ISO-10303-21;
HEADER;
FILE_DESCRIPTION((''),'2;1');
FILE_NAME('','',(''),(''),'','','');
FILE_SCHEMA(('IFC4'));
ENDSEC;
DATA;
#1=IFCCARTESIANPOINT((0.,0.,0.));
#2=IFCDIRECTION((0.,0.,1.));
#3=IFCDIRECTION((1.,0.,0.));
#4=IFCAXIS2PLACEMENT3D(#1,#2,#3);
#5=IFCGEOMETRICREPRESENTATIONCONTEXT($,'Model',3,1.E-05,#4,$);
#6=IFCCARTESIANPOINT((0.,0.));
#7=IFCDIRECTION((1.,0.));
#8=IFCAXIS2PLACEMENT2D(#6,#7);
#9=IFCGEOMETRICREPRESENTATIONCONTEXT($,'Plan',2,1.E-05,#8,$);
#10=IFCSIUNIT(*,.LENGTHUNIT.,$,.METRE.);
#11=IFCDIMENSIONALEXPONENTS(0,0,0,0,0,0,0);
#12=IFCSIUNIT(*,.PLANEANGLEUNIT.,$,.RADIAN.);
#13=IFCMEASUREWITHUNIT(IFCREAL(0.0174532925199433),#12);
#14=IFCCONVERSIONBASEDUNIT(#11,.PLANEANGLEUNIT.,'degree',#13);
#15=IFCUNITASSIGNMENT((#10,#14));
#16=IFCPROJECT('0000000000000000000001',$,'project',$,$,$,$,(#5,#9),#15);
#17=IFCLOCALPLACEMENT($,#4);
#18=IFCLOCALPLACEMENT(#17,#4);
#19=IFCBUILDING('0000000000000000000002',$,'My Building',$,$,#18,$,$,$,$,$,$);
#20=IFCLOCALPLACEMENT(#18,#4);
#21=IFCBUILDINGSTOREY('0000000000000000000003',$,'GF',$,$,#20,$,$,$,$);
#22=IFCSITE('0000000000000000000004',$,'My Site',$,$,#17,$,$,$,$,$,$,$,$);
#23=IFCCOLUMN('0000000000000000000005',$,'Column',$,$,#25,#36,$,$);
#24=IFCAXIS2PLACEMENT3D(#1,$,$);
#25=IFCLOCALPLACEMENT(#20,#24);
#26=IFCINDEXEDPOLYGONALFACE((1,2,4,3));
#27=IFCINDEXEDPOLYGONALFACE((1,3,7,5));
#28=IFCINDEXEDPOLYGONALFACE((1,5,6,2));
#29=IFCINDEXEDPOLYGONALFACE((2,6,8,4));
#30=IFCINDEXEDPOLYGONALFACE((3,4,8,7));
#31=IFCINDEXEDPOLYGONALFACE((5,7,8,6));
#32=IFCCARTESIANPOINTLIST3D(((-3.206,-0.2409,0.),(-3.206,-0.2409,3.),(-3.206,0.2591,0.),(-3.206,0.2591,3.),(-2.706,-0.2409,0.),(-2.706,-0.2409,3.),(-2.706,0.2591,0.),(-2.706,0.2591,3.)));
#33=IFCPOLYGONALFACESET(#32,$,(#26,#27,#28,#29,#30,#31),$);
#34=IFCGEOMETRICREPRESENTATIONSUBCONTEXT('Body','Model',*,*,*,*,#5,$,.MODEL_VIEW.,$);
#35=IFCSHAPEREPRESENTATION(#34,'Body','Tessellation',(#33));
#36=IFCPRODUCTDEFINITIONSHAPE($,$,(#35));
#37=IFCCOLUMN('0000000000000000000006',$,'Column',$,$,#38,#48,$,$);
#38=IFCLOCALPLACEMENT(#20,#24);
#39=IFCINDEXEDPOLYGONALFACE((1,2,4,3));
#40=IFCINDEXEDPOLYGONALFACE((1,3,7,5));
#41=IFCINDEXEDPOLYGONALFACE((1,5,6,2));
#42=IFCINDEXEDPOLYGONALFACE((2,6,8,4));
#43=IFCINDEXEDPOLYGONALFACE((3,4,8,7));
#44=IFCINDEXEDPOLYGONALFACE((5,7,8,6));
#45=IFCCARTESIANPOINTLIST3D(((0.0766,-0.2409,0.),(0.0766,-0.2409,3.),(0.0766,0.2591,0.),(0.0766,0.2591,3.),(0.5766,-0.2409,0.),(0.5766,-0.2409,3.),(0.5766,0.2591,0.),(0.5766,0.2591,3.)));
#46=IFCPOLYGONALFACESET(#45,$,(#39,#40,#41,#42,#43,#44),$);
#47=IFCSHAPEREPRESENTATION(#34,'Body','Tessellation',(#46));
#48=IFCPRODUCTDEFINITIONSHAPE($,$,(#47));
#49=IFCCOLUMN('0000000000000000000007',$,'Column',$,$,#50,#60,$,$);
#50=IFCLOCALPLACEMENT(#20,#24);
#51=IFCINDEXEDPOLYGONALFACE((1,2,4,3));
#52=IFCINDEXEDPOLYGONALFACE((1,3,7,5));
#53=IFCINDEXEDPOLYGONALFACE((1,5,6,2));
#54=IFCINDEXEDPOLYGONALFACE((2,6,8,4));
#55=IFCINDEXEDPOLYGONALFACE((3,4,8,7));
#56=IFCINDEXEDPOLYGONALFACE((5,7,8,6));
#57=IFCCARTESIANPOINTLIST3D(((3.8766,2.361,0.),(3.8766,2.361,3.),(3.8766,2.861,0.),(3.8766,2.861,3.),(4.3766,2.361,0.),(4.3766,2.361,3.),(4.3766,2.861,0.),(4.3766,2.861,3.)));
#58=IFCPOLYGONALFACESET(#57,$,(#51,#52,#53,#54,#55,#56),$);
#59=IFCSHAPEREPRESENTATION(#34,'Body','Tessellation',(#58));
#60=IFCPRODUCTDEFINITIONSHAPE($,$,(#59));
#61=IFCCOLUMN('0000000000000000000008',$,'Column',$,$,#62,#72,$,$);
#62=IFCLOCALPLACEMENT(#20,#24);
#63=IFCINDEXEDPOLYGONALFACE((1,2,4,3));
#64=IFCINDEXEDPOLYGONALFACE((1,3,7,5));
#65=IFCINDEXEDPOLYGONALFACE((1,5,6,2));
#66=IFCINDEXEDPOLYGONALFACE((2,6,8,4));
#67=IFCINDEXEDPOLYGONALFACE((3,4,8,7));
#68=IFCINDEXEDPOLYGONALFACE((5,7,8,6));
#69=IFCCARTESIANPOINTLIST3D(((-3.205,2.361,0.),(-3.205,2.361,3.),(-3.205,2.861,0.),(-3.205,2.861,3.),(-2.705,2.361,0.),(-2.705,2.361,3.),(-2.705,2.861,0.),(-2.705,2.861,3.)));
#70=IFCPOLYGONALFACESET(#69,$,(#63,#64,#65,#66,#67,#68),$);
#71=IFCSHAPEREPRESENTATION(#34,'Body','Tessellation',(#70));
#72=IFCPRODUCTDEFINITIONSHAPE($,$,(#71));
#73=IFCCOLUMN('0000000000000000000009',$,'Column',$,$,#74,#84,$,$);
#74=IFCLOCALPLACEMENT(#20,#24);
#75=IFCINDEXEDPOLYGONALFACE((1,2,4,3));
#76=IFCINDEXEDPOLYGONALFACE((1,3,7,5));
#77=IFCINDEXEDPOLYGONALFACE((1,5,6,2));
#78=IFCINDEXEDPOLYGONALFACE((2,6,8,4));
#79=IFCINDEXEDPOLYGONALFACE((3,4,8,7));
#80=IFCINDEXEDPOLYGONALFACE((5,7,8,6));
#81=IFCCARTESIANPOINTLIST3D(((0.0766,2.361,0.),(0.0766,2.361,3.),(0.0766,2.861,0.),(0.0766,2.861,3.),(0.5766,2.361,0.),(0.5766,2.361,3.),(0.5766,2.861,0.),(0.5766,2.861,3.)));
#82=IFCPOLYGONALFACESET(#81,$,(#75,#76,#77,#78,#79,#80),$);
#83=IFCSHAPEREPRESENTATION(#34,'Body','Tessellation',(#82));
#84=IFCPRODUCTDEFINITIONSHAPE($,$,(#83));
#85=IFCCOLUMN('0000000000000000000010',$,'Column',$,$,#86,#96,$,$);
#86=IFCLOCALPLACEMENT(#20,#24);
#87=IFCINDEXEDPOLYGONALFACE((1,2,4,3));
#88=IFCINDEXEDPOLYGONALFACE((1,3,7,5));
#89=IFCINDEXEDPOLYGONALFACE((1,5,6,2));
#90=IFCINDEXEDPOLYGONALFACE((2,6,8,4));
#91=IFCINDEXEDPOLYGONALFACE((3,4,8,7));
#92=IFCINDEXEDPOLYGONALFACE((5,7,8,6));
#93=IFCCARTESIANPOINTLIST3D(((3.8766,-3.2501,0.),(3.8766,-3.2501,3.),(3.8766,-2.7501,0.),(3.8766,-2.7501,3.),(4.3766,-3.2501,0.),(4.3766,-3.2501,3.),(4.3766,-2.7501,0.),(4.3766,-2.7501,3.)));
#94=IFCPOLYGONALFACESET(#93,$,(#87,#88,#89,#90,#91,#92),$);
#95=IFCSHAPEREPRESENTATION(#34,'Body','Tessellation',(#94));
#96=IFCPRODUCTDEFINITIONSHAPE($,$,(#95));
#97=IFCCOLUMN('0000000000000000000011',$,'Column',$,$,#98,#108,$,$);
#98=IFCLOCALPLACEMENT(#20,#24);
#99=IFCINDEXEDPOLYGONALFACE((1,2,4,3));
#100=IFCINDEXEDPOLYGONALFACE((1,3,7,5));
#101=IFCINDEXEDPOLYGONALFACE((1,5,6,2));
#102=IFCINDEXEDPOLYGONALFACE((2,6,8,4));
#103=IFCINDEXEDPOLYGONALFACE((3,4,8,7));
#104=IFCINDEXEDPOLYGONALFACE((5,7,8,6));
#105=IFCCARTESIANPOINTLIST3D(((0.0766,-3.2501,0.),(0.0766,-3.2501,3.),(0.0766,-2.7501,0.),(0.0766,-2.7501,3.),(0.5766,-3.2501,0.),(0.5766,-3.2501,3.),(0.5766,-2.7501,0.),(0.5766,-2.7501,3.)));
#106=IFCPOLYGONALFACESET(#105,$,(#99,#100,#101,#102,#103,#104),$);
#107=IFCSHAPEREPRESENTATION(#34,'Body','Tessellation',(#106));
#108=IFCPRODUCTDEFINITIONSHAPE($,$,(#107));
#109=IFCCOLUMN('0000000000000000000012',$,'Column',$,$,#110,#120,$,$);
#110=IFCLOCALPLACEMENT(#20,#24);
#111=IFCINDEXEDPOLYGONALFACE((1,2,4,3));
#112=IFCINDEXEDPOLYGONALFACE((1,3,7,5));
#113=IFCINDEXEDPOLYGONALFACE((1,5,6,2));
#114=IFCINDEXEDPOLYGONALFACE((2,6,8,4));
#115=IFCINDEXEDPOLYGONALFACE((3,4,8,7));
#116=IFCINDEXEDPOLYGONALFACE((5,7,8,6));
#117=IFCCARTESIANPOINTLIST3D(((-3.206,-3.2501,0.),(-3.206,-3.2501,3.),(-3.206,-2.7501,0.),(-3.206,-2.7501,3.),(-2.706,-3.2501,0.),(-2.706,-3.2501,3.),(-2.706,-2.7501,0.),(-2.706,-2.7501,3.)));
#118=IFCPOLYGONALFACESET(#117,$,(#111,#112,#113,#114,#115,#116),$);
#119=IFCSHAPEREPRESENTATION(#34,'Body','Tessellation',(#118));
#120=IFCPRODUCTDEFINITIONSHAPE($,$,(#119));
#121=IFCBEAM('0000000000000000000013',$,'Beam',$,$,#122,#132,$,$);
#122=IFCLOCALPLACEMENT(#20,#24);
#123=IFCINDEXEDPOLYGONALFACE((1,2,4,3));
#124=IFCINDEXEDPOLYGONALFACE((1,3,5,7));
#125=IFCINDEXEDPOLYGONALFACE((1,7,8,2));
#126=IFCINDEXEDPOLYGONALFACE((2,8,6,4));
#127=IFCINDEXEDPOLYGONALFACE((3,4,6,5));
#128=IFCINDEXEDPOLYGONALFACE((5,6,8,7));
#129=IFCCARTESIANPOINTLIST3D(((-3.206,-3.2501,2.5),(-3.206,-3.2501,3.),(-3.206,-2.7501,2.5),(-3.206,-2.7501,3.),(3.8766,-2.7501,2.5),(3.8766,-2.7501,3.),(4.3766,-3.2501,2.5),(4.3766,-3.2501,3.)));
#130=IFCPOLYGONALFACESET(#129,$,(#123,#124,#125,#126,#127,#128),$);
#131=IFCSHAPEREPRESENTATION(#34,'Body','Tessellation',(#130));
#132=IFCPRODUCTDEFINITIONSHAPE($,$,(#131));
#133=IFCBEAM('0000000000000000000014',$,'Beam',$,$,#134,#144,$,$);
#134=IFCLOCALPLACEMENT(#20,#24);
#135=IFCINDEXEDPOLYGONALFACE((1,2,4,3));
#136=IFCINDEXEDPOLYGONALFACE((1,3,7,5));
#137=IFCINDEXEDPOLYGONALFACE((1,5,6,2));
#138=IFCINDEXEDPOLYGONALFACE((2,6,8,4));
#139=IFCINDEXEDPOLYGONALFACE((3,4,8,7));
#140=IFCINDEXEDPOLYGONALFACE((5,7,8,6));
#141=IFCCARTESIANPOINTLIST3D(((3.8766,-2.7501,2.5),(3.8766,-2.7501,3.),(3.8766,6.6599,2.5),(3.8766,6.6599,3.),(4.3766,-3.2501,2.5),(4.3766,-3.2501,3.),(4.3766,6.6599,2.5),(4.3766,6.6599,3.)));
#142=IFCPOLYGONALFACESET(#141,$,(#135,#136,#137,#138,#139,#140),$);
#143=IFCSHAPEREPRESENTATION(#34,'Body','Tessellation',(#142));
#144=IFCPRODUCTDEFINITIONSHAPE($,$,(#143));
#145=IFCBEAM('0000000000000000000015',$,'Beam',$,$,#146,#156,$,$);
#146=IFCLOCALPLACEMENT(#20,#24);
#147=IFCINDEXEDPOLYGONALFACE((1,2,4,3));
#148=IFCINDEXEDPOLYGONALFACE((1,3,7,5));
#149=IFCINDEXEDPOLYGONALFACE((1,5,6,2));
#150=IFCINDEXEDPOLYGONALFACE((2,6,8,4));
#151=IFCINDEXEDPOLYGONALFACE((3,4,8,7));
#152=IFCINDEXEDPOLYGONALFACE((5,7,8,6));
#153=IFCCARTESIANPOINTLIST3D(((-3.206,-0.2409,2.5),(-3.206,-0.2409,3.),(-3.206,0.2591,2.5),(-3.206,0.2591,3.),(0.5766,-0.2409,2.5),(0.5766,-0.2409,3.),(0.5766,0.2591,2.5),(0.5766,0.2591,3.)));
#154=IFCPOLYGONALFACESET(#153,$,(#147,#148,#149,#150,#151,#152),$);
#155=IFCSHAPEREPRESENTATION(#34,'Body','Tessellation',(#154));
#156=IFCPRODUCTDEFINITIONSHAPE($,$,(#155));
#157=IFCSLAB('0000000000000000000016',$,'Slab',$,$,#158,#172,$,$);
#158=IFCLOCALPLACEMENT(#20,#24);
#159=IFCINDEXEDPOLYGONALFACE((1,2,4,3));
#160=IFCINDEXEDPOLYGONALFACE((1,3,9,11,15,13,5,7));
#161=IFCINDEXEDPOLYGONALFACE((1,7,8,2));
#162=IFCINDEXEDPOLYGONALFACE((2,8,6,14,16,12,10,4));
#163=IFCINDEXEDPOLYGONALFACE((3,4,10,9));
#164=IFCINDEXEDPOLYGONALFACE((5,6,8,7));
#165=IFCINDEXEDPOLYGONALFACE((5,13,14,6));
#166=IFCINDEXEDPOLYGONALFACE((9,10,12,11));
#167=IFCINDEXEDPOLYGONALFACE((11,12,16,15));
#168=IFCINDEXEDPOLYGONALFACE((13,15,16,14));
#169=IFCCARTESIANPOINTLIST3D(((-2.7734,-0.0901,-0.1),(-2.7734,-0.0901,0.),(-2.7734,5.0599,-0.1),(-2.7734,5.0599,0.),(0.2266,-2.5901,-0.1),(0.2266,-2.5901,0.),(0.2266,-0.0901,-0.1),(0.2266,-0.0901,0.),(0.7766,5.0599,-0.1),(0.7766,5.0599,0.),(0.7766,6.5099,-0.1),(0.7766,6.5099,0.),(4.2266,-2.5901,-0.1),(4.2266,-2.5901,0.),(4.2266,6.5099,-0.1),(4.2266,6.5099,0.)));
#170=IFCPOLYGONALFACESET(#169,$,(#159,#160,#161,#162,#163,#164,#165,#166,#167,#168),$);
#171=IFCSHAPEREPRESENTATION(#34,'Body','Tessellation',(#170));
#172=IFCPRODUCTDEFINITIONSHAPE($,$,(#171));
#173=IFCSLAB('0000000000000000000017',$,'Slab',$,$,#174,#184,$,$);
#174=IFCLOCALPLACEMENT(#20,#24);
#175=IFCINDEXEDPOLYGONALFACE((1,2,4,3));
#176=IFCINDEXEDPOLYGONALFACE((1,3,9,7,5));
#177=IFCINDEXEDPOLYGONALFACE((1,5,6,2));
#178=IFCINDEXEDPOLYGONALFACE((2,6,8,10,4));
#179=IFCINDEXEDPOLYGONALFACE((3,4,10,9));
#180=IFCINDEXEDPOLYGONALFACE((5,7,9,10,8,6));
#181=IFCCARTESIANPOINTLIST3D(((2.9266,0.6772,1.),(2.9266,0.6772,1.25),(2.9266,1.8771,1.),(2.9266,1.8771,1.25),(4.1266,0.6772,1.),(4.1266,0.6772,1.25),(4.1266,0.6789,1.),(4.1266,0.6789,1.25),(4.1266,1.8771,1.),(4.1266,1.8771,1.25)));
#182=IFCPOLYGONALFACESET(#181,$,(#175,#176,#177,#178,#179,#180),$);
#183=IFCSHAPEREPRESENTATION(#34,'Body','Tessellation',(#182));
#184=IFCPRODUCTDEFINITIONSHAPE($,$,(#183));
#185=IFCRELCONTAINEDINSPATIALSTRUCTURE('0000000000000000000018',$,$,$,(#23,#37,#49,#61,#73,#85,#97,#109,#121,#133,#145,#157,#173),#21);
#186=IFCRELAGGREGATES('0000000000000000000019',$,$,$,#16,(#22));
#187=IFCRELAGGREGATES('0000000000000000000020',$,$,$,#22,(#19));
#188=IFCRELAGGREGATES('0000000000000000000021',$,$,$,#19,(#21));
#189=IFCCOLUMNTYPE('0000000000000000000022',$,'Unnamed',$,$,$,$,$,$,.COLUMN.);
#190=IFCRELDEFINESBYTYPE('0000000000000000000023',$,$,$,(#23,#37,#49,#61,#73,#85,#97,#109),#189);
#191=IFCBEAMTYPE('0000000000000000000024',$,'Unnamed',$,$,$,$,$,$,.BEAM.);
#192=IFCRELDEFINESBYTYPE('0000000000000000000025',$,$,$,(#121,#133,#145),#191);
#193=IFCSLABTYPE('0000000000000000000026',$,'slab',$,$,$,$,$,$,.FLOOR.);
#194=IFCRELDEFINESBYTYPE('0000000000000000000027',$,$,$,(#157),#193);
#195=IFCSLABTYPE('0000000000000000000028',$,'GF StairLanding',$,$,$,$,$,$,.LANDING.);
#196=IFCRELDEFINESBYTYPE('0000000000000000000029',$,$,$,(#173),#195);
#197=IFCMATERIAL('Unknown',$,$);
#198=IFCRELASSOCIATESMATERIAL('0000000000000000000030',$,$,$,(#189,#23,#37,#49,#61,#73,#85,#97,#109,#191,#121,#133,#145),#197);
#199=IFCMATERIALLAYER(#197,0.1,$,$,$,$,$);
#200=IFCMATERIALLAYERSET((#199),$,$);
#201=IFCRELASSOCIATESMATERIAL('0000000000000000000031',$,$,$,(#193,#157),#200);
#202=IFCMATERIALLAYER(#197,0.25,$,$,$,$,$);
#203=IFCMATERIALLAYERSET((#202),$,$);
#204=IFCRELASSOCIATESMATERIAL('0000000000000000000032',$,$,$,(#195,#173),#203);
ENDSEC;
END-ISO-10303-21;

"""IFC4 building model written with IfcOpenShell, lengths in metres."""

from ifc_helpers import new_model, entity, si_unit, converted_unit, frame, origin_with_axes, origin_2d_with_axis, place, context, subcontext, project, spatial, indexed_curve, rectangle, outline, extrude, clip, halfspace, material, layer, layer_set, layer_usage, material_profile, profile_set, profile_usage, type_object, element, save


model = new_model("IFC4")

# Units and contexts
model_context = context("Model", 3, precision=1e-05, world=origin_with_axes())
plan_context = context("Plan", 2, precision=1e-05, world=origin_2d_with_axis())
body_context_1 = subcontext(model_context, "Body", "Model", "MODEL_VIEW")
ifc_project = project(units=[si_unit("LENGTHUNIT", "METRE"), converted_unit("PLANEANGLEUNIT", "degree", entity("IfcReal", 0.0174532925199433), si_unit("PLANEANGLEUNIT", "RADIAN"), dimensions=[0, 0, 0, 0, 0, 0, 0])], contexts=[model_context, plan_context])

# Site, building, storey
site_placement = place(None, origin_with_axes())
site = spatial("IfcSite", under=ifc_project, at=site_placement, Name="My Site")
building_placement = place(site_placement, origin_with_axes())
building = spatial("IfcBuilding", under=site, at=building_placement, Name="My Building")
storey_placement = place(building_placement, origin_with_axes())
storey = spatial("IfcBuildingStorey", under=building, at=storey_placement, Name="GF")

# Columns
ifc_material = material(Name="Unknown")
ifc_material_profile_1 = material_profile(ifc_material, rectangle(XDim=0.5, YDim=0.5))
ifc_profile_set_1 = profile_set([ifc_material_profile_1])
ifc_profile_usage_1 = profile_usage(ifc_profile_set_1, cardinal=5)
column_type = type_object("IfcColumnType", Name="Unnamed", PredefinedType="COLUMN", material=ifc_profile_set_1)
column_1_placement = place(storey_placement, frame((-2.956, 0.0091, 0.0), z_axis=(0.0, 0.0, 1.0), x_axis=(1.0, 0.0, 0.0)))
element("IfcColumn", 1, at=column_1_placement, inside=storey, type_object=column_type, material=ifc_profile_usage_1, Name="Column", context=body_context_1, shape_type="SweptSolid", body=[
    extrude(rectangle(XDim=0.5, YDim=0.5), origin_with_axes(), (0.0, 0.0, 1.0), 3.0),
])
ifc_profile_usage_2 = profile_usage(ifc_profile_set_1, cardinal=5)
column_2_placement = place(storey_placement, frame((0.3266, 0.0091, 0.0), z_axis=(0.0, 0.0, 1.0), x_axis=(1.0, 0.0, 0.0)))
element("IfcColumn", 2, at=column_2_placement, inside=storey, type_object=column_type, material=ifc_profile_usage_2, Name="Column", context=body_context_1, shape_type="SweptSolid", body=[
    extrude(rectangle(XDim=0.5, YDim=0.5), origin_with_axes(), (0.0, 0.0, 1.0), 3.0),
])
ifc_profile_usage_3 = profile_usage(ifc_profile_set_1, cardinal=5)
column_3_placement = place(storey_placement, frame((4.1266, 2.611, 0.0), z_axis=(0.0, 0.0, 1.0), x_axis=(1.0, 0.0, 0.0)))
element("IfcColumn", 3, at=column_3_placement, inside=storey, type_object=column_type, material=ifc_profile_usage_3, Name="Column", context=body_context_1, shape_type="SweptSolid", body=[
    extrude(rectangle(XDim=0.5, YDim=0.5), origin_with_axes(), (0.0, 0.0, 1.0), 3.0),
])
ifc_profile_usage_4 = profile_usage(ifc_profile_set_1, cardinal=5)
column_4_placement = place(storey_placement, frame((-2.955, 2.611, 0.0), z_axis=(0.0, 0.0, 1.0), x_axis=(1.0, 0.0, 0.0)))
element("IfcColumn", 4, at=column_4_placement, inside=storey, type_object=column_type, material=ifc_profile_usage_4, Name="Column", context=body_context_1, shape_type="SweptSolid", body=[
    extrude(rectangle(XDim=0.5, YDim=0.5), origin_with_axes(), (0.0, 0.0, 1.0), 3.0),
])
ifc_profile_usage_5 = profile_usage(ifc_profile_set_1, cardinal=5)
column_5_placement = place(storey_placement, frame((0.3266, 2.611, 0.0), z_axis=(0.0, 0.0, 1.0), x_axis=(1.0, 0.0, 0.0)))
element("IfcColumn", 5, at=column_5_placement, inside=storey, type_object=column_type, material=ifc_profile_usage_5, Name="Column", context=body_context_1, shape_type="SweptSolid", body=[
    extrude(rectangle(XDim=0.5, YDim=0.5), origin_with_axes(), (0.0, 0.0, 1.0), 3.0),
])
ifc_profile_usage_6 = profile_usage(ifc_profile_set_1, cardinal=5)
column_6_placement = place(storey_placement, frame((4.1266, -3.0001, 0.0), z_axis=(0.0, 0.0, 1.0), x_axis=(1.0, 0.0, 0.0)))
element("IfcColumn", 6, at=column_6_placement, inside=storey, type_object=column_type, material=ifc_profile_usage_6, Name="Column", context=body_context_1, shape_type="SweptSolid", body=[
    extrude(rectangle(XDim=0.5, YDim=0.5), origin_with_axes(), (0.0, 0.0, 1.0), 3.0),
])
ifc_profile_usage_7 = profile_usage(ifc_profile_set_1, cardinal=5)
column_7_placement = place(storey_placement, frame((0.3266, -3.0001, 0.0), z_axis=(0.0, 0.0, 1.0), x_axis=(1.0, 0.0, 0.0)))
element("IfcColumn", 7, at=column_7_placement, inside=storey, type_object=column_type, material=ifc_profile_usage_7, Name="Column", context=body_context_1, shape_type="SweptSolid", body=[
    extrude(rectangle(XDim=0.5, YDim=0.5), origin_with_axes(), (0.0, 0.0, 1.0), 3.0),
])
ifc_profile_usage_8 = profile_usage(ifc_profile_set_1, cardinal=5)
column_8_placement = place(storey_placement, frame((-2.956, -3.0001, 0.0), z_axis=(0.0, 0.0, 1.0), x_axis=(1.0, 0.0, 0.0)))
element("IfcColumn", 8, at=column_8_placement, inside=storey, type_object=column_type, material=ifc_profile_usage_8, Name="Column", context=body_context_1, shape_type="SweptSolid", body=[
    extrude(rectangle(XDim=0.5, YDim=0.5), origin_with_axes(), (0.0, 0.0, 1.0), 3.0),
])

# Beams
ifc_material_profile_2 = material_profile(ifc_material, rectangle(XDim=0.5, YDim=0.5))
ifc_profile_set_2 = profile_set([ifc_material_profile_2])
ifc_profile_usage_9 = profile_usage(ifc_profile_set_2, cardinal=9)
beam_type = type_object("IfcBeamType", Name="Unnamed", PredefinedType="BEAM", material=ifc_profile_set_2)
beam_1_placement = place(storey_placement, frame((-3.206, -3.2501, 3.0), z_axis=(1.0, 0.0, 0.0), x_axis=(0.0, 1.0, 0.0)))
element("IfcBeam", 9, at=beam_1_placement, inside=storey, type_object=beam_type, material=ifc_profile_usage_9, Name="Beam", context=body_context_1, shape_type="Clipping", body=[
    clip(extrude(rectangle(XDim=0.5, YDim=0.5), frame((0.25, -0.25, 0.0), z_axis=(0.0, 0.0, 1.0), x_axis=(1.0, 0.0, 0.0)), (0.0, 0.0, 1.0), 7.5826), halfspace(frame((0.0, -3.0, 7.5826), z_axis=(0.707106, 0.0, 0.707108), x_axis=(0.0, -1.0, 0.0)), False)),
])
ifc_profile_usage_10 = profile_usage(ifc_profile_set_2, cardinal=9)
beam_2_placement = place(storey_placement, frame((4.3766, -3.2501, 3.0), z_axis=(0.000003, 1.0, 0.0), x_axis=(-1.0, 0.000003, 0.0)))
element("IfcBeam", 10, at=beam_2_placement, inside=storey, type_object=beam_type, material=ifc_profile_usage_10, Name="Beam", context=body_context_1, shape_type="Clipping", body=[
    clip(extrude(rectangle(XDim=0.5, YDim=0.5), frame((0.25, -0.25, 0.0), z_axis=(0.0, 0.0, 1.0), x_axis=(1.0, 0.0, 0.0)), (0.0, 0.0, 1.0), 9.91), halfspace(frame((0.0, -3.0, 0.0), z_axis=(0.707106, 0.0, -0.707107), x_axis=(0.0, -1.0, 0.0)), False)),
])
ifc_profile_usage_11 = profile_usage(ifc_profile_set_2, cardinal=7)
beam_3_placement = place(storey_placement, frame((-3.206, 0.2591, 3.0), z_axis=(1.0, 0.0, 0.0), x_axis=(0.0, 1.0, 0.0)))
element("IfcBeam", 11, at=beam_3_placement, inside=storey, type_object=beam_type, material=ifc_profile_usage_11, Name="Beam", context=body_context_1, shape_type="SweptSolid", body=[
    extrude(rectangle(XDim=0.5, YDim=0.5), frame((-0.25, -0.25, 0.0), z_axis=(0.0, 0.0, 1.0), x_axis=(1.0, 0.0, 0.0)), (0.0, 0.0, 1.0), 3.7827),
])

# Slabs
ifc_layer_1 = layer(ifc_material, 0.1)
ifc_layer_set_1 = layer_set([ifc_layer_1])
ifc_layer_usage_1 = layer_usage(ifc_layer_set_1, "AXIS3", "POSITIVE", -0.1)
slab_type_1 = type_object("IfcSlabType", Name="slab", PredefinedType="FLOOR", material=ifc_layer_set_1)
slab_1_placement = place(storey_placement, frame((4.2266, -2.5901, 0.0), z_axis=(0.0, 0.0, 1.0), x_axis=(1.0, 0.0, 0.0)))
element("IfcSlab", 12, at=slab_1_placement, inside=storey, type_object=slab_type_1, material=ifc_layer_usage_1, Name="Slab", context=body_context_1, shape_type="SweptSolid", body=[
    extrude(outline(indexed_curve([(0.0, 0.0), (0.0, 9.1), (-3.45, 9.1), (-3.45, 7.65), (-7.0, 7.65), (-7.0, 2.5), (-4.0, 2.5), (-4.0, 0.0), (0.0, 0.0)])), frame((0.0, 0.0, -0.1), z_axis=(0.0, 0.0, 1.0), x_axis=(1.0, 0.0, 0.0)), (0.0, 0.0, 1.0), 0.1),
])
ifc_layer_2 = layer(ifc_material, 0.25)
ifc_layer_set_2 = layer_set([ifc_layer_2])
ifc_layer_usage_2 = layer_usage(ifc_layer_set_2, "AXIS3", "POSITIVE", -0.1)
slab_type_2 = type_object("IfcSlabType", Name="GF StairLanding", PredefinedType="LANDING", material=ifc_layer_set_2)
slab_2_placement = place(storey_placement, frame((2.9266, 1.8771, 1.1), z_axis=(0.0, 0.0, 1.0), x_axis=(1.0, 0.0, 0.0)))
element("IfcSlab", 13, at=slab_2_placement, inside=storey, type_object=slab_type_2, material=ifc_layer_usage_2, Name="Slab", context=body_context_1, shape_type="SweptSolid", body=[
    extrude(outline(indexed_curve([(0.0, 0.0), (1.1999, 0.0), (1.1999, -1.1982), (1.1999, -1.1999), (0.0, -1.1999), (0.0, 0.0)])), frame((0.0, 0.0, -0.1), z_axis=(0.0, 0.0, 1.0), x_axis=(1.0, 0.0, 0.0)), (0.0, 0.0, 1.0), 0.25),
])

save(model, "model.ifc")
